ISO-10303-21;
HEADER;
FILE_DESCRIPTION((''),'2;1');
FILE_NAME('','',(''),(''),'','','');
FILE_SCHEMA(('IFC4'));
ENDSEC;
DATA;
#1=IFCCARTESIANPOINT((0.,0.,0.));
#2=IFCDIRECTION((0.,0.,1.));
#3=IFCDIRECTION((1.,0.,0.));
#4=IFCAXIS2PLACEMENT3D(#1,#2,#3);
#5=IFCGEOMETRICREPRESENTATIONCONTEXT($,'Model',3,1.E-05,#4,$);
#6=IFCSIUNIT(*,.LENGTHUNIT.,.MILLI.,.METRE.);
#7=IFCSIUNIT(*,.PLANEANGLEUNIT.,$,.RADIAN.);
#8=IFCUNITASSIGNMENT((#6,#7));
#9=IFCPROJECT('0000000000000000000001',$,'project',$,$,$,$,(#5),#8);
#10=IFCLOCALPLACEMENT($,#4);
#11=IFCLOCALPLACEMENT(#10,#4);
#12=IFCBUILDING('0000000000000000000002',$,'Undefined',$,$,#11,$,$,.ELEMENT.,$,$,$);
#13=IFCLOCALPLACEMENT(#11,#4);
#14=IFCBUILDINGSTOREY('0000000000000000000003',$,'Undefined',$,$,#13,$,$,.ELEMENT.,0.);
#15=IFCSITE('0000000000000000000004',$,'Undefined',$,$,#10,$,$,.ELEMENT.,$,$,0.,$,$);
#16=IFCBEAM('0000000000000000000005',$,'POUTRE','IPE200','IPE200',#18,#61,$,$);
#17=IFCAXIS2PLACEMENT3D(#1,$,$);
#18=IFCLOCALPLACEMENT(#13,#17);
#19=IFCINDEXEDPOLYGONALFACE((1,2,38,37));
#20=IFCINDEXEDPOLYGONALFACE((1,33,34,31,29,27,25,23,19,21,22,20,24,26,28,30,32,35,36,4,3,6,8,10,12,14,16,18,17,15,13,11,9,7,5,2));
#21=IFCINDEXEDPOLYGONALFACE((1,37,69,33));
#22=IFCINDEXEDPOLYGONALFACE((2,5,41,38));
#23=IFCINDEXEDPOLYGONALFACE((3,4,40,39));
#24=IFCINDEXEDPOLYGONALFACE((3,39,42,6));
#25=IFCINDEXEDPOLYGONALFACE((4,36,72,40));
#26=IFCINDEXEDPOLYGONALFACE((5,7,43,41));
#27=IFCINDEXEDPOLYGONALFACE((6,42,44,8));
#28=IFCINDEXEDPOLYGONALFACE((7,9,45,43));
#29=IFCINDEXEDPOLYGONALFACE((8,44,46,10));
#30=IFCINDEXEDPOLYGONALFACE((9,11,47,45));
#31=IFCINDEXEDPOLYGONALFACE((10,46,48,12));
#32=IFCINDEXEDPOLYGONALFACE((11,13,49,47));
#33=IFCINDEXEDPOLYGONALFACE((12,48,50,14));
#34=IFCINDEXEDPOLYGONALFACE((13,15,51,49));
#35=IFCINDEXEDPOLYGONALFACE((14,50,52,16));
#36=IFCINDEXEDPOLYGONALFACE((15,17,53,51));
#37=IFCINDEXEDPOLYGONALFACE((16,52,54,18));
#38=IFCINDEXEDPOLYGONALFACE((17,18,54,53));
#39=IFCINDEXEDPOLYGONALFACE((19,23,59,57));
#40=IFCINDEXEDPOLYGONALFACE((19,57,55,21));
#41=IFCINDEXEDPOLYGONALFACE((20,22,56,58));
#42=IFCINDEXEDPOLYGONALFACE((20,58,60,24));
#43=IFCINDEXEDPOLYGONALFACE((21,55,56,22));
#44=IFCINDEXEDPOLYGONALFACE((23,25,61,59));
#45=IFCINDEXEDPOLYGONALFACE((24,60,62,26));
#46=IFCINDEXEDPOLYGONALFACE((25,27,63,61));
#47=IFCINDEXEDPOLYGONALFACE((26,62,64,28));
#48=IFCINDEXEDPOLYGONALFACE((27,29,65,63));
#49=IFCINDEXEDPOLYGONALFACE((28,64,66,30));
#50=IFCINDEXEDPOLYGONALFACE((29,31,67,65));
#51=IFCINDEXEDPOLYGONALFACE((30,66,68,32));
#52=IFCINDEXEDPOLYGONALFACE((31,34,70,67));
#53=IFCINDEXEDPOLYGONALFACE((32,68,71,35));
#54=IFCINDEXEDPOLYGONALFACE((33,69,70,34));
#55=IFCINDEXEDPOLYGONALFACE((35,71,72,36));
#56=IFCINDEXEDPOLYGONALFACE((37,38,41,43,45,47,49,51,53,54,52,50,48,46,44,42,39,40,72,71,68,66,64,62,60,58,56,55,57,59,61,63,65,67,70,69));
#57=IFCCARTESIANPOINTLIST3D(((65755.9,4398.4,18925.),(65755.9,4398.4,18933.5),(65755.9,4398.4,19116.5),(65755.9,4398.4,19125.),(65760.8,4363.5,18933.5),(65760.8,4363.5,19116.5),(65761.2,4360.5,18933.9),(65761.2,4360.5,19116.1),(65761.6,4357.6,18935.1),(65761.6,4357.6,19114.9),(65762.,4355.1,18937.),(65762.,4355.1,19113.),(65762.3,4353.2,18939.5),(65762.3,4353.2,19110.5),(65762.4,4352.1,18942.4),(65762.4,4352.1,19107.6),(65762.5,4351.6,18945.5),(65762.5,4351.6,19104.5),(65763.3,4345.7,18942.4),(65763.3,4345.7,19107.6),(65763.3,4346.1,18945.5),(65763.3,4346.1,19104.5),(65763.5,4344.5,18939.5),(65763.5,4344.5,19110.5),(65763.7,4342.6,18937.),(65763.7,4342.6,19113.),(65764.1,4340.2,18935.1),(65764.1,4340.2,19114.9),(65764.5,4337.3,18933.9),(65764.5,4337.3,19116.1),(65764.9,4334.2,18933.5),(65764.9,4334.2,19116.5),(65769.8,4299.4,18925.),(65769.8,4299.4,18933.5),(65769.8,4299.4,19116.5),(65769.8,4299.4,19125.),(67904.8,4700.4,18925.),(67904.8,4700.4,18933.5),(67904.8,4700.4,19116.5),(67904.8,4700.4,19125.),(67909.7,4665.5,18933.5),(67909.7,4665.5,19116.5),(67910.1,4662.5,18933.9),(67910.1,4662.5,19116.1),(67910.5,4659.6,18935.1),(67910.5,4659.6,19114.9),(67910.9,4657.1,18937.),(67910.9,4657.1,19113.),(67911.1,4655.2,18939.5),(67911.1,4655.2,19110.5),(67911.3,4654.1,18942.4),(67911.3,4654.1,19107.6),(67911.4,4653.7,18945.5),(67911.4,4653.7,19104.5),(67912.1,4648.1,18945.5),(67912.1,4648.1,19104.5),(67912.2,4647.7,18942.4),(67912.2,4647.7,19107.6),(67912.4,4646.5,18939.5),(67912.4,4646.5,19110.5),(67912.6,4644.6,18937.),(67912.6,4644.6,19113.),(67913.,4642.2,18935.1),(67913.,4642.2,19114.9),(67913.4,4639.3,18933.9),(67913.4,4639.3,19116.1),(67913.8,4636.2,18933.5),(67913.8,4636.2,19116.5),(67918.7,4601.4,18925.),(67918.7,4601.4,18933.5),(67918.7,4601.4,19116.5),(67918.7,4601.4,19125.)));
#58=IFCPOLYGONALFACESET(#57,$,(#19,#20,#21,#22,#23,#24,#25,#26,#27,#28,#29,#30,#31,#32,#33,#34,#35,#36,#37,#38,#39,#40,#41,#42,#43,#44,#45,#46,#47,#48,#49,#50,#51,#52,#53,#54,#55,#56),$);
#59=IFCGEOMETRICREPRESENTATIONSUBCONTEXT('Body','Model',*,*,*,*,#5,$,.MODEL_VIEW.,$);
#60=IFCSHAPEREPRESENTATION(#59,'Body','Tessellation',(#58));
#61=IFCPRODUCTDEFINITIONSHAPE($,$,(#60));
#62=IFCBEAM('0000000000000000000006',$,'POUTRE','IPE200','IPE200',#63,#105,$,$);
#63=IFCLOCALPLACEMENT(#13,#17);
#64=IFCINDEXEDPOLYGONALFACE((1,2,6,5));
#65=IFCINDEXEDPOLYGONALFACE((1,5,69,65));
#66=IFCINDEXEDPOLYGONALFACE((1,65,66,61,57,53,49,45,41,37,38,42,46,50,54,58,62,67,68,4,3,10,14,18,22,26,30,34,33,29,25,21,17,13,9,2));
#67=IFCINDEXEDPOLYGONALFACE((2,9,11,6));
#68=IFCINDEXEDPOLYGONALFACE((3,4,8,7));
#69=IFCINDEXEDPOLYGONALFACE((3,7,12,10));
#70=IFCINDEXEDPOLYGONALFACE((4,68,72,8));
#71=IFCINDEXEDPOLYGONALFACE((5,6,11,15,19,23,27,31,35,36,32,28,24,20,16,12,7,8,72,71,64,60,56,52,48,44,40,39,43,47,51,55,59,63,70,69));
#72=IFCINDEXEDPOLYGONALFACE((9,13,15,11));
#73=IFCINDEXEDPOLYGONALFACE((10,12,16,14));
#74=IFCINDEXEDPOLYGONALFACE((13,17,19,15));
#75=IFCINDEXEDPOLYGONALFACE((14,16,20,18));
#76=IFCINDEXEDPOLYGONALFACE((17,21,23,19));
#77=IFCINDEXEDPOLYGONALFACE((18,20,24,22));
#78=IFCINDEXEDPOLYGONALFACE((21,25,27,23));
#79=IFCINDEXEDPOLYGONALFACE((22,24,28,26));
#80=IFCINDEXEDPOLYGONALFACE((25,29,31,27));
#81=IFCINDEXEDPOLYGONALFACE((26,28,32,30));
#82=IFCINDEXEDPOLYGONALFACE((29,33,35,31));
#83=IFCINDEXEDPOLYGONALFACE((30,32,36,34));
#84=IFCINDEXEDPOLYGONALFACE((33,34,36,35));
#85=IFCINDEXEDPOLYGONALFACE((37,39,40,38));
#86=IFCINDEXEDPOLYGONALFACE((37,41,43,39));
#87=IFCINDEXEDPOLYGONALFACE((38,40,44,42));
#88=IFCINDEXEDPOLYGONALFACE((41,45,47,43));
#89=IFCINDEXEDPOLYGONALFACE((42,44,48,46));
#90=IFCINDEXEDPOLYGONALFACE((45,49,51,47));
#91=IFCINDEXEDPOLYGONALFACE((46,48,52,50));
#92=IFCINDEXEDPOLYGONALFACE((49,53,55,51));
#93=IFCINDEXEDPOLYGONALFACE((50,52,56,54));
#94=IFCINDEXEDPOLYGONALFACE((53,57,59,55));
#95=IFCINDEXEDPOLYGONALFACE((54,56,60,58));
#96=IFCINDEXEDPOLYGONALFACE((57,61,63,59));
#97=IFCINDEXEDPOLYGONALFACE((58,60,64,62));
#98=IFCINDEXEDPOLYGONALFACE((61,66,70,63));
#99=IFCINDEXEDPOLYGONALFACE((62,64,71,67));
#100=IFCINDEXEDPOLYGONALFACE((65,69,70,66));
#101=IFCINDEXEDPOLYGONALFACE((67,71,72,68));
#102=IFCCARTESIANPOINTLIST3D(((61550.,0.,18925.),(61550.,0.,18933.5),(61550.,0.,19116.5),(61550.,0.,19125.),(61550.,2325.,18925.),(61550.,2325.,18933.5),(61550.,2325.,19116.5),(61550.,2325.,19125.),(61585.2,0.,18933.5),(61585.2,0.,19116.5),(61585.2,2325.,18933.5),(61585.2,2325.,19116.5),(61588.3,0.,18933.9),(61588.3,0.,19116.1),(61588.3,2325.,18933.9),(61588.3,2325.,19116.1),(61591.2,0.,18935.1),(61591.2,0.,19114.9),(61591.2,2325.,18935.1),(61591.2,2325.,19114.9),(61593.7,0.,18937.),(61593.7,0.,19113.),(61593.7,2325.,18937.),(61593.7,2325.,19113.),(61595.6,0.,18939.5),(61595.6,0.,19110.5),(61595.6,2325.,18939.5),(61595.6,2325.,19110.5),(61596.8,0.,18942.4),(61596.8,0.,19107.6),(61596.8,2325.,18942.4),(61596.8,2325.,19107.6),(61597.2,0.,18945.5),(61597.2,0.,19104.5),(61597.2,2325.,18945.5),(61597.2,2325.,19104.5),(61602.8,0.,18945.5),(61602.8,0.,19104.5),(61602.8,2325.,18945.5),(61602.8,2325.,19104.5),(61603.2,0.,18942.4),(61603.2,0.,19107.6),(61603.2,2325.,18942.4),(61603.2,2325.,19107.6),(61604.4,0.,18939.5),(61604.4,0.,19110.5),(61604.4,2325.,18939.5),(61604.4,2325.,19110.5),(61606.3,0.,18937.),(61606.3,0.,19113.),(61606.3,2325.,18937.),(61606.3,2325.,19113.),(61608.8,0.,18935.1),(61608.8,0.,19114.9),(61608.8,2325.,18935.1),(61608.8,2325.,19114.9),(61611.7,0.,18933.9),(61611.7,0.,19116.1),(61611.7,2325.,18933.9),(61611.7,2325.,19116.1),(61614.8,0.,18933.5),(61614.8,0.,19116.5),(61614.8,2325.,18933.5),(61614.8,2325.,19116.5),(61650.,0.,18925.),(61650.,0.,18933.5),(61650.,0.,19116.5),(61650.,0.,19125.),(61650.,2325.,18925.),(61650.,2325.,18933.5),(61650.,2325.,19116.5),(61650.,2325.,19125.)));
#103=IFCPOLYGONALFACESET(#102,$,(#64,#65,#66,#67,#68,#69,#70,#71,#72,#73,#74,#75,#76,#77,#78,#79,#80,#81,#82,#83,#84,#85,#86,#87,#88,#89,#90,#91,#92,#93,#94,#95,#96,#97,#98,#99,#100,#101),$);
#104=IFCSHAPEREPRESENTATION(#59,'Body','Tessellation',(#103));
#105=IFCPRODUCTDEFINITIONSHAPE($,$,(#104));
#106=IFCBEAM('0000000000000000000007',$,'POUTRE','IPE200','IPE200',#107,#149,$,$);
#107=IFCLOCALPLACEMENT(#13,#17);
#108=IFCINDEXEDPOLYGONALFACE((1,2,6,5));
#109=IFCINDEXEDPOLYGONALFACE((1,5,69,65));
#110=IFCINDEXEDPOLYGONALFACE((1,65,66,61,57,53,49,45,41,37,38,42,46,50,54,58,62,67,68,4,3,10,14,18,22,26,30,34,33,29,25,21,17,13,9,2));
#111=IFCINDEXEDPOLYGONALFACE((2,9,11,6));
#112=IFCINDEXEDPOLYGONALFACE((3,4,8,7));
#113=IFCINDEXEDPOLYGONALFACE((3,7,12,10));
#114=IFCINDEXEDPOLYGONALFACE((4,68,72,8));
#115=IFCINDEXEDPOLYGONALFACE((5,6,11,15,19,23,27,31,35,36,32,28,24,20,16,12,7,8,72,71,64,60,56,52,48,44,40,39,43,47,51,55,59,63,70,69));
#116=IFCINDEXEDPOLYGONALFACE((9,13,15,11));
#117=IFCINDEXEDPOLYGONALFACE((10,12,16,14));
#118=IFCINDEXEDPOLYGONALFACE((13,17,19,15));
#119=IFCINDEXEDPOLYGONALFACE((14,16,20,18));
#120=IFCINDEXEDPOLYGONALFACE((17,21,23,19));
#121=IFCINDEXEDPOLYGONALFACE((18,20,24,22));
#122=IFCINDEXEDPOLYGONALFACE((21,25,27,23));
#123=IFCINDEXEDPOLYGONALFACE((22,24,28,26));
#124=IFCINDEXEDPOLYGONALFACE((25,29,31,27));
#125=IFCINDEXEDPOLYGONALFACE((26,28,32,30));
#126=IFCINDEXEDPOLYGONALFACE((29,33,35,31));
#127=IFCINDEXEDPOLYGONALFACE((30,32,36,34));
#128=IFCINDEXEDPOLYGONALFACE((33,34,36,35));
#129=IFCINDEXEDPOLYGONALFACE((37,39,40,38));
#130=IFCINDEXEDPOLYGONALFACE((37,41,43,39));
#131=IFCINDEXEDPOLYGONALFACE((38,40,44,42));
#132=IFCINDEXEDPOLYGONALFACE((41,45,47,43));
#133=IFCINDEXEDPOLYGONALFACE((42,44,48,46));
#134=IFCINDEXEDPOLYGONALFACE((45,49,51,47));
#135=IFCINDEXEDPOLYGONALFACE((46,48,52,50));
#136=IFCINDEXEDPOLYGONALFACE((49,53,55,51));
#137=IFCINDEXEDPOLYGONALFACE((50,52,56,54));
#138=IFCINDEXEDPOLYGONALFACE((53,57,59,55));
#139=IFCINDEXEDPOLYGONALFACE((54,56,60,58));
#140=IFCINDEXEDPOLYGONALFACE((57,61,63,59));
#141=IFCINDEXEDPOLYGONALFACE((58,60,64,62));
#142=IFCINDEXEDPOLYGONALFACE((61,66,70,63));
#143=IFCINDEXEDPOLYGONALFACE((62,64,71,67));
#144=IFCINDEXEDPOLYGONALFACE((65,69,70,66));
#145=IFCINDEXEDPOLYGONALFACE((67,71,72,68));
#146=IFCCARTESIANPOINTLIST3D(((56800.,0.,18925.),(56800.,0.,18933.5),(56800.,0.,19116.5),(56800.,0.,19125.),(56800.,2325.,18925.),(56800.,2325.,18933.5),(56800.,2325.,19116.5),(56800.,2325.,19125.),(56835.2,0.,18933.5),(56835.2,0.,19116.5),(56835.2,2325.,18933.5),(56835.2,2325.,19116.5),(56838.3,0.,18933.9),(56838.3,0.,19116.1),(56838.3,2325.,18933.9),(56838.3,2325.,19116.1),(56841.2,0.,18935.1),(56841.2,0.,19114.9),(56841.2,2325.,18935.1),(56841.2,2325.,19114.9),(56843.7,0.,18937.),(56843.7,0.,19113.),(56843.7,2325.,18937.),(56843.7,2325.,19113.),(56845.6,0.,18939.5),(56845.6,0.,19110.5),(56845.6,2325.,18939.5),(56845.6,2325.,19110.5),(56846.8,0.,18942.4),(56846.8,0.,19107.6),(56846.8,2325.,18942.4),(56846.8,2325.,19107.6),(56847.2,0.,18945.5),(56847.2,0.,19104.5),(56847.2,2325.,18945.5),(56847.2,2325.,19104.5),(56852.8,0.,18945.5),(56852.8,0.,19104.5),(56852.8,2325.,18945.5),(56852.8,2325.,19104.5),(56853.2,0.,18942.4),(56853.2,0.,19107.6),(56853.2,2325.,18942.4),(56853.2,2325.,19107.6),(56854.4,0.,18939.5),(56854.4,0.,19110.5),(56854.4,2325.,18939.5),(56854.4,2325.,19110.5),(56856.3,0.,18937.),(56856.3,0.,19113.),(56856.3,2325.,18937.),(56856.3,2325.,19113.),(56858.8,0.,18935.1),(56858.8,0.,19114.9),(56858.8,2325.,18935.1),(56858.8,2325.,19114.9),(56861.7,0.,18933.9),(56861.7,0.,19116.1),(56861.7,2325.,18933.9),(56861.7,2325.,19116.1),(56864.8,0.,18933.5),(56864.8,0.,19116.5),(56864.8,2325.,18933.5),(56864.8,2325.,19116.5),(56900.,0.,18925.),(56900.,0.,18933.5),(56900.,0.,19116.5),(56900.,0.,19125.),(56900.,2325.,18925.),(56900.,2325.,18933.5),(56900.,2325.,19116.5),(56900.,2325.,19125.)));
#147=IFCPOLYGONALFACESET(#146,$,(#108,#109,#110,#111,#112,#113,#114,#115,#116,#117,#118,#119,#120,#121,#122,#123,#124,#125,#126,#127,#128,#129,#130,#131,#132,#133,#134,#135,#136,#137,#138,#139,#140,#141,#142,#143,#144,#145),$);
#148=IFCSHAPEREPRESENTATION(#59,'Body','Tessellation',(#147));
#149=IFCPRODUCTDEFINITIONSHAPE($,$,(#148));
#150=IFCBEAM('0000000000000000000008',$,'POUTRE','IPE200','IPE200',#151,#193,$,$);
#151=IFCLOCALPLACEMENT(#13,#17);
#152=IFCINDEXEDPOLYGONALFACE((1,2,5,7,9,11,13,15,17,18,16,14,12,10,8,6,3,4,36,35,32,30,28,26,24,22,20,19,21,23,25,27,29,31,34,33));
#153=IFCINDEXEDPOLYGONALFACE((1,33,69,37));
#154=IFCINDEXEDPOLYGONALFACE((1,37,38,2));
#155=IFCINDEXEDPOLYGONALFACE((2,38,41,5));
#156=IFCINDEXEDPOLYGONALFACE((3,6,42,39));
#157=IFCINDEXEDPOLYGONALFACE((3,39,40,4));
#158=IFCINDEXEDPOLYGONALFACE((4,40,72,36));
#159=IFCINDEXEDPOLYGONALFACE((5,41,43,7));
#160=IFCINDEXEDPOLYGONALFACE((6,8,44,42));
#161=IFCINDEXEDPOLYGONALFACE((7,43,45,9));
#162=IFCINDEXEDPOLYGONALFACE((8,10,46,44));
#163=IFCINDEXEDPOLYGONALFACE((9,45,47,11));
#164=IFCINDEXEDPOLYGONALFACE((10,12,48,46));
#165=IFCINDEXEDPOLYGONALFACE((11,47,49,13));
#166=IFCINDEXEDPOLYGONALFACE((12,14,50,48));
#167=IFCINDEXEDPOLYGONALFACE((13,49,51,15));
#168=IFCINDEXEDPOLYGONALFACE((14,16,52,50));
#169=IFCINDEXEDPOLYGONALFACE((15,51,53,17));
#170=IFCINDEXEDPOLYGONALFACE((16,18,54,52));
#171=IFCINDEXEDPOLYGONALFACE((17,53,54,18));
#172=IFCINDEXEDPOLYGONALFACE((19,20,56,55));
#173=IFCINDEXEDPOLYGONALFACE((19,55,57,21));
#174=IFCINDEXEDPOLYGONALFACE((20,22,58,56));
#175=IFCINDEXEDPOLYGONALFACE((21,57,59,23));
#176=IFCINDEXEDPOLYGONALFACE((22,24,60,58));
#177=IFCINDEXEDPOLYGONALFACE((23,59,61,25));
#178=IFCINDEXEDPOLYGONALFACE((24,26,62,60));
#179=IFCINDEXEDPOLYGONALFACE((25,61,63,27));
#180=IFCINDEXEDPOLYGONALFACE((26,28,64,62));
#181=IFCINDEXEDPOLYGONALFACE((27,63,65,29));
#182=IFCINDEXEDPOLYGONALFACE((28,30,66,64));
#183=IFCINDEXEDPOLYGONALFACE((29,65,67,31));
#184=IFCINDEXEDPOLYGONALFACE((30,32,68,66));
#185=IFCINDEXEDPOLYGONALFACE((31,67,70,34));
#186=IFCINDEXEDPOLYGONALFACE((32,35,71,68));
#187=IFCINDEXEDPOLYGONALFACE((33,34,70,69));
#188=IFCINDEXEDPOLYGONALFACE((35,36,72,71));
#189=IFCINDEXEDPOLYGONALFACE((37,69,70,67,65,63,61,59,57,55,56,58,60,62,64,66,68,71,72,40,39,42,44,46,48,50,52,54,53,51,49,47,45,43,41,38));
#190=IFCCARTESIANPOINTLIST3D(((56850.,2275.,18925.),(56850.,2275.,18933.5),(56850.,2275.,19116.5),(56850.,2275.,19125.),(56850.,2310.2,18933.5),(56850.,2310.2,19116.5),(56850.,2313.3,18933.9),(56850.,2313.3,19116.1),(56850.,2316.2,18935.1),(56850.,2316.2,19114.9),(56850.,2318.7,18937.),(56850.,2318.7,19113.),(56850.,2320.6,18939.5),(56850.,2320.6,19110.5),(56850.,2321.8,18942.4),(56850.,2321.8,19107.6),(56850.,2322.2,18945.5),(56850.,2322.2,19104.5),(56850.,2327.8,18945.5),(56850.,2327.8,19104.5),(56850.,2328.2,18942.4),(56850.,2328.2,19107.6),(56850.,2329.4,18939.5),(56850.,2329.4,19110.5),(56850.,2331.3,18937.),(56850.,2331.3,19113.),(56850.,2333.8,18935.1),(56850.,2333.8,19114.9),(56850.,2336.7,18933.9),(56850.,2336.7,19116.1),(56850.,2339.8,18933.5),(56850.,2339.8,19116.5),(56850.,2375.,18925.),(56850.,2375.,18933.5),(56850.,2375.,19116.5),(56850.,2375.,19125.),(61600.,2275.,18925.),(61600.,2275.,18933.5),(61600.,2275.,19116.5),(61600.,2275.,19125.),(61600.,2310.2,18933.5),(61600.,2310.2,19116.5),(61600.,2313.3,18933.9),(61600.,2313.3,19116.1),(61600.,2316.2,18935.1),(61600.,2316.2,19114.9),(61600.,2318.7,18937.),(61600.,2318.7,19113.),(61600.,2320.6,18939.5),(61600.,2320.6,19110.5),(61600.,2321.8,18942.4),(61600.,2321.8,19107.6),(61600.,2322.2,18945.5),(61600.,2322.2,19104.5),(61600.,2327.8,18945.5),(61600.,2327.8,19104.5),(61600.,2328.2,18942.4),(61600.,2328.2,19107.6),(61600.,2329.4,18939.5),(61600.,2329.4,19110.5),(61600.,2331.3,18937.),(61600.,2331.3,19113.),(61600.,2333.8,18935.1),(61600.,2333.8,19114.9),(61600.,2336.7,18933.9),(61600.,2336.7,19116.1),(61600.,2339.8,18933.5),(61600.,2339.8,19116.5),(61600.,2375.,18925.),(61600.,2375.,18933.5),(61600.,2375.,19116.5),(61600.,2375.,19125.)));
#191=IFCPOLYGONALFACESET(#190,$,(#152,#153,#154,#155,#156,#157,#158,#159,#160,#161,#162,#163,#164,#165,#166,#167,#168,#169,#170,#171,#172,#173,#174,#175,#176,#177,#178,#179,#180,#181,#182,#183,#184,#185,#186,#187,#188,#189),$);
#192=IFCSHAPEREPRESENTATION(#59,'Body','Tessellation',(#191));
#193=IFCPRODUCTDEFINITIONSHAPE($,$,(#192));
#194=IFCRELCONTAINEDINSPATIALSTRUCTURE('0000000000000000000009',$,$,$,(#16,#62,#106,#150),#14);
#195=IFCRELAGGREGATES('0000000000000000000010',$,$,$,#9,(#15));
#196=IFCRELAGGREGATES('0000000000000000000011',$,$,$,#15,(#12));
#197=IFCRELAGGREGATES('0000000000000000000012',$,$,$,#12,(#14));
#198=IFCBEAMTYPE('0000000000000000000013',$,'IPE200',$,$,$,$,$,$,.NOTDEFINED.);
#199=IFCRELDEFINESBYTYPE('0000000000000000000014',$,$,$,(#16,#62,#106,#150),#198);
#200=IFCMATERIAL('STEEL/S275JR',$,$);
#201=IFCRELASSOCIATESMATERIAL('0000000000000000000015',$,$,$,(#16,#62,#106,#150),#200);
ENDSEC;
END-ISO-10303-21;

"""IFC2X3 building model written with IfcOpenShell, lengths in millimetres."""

from ifc_helpers import new_model, si_unit, frame, origin_with_axes, origin_2d_with_axis, place, context, subcontext, project, spatial, i_section, extrude, material, type_object, element, save


model = new_model("IFC2X3")

# Units and contexts
model_context = context("Model", 3, precision=1e-05, world=origin_with_axes())
body_context = subcontext(model_context, "Body", "Model", "MODEL_VIEW")
ifc_project = project(units=[si_unit("LENGTHUNIT", "METRE", prefix="MILLI"), si_unit("PLANEANGLEUNIT", "RADIAN")], contexts=[model_context])

# Site, building, storey
site_placement = place(None, origin_with_axes())
site = spatial("IfcSite", under=ifc_project, at=site_placement, Name="Undefined", CompositionType="ELEMENT", RefElevation=0.0)
building_placement = place(site_placement, origin_with_axes())
building = spatial("IfcBuilding", under=site, at=building_placement, Name="Undefined", CompositionType="ELEMENT")
storey_placement = place(building_placement, origin_with_axes())
storey = spatial("IfcBuildingStorey", under=building, at=storey_placement, Name="Undefined", CompositionType="ELEMENT", Elevation=0.0)

# Shared definitions
ifc_material_1 = material(Name="STEEL/S275JR")

# Beams
beam_type_1 = type_object("IfcBeamType", Name="IPE200", PredefinedType="NOTDEFINED")
beam_1_placement = place(storey_placement, frame((67911.7, 4650.9, 19025.0), z_axis=(-0.000014, -0.000002, 1.0), x_axis=(-0.990268, -0.139173, -0.000014)))
element("IfcBeam", 1, at=beam_1_placement, inside=storey, type_object=beam_type_1, material=ifc_material_1, Name="POUTRE", Description="IPE200", ObjectType="IPE200", context=body_context, shape_type="SweptSolid", body=[
    extrude(i_section(OverallWidth=100.0, OverallDepth=200.0, WebThickness=5.6, FlangeThickness=8.5, FilletRadius=12.0, at=origin_2d_with_axis()), frame((2170.0, 0.0, 0.0), z_axis=(-1.0, 0.0, 0.0), x_axis=(0.0, -1.0, 0.0)), (0.0, 0.0, 1.0), 2170.0),
])
for number, where, z_axis, x_axis, name in (
    (2, (61600.0, 0.0, 19025.0), (0.0, 0.000013, 1.0), (0.0, 1.0, -0.000013), "POUTRE"),
    (3, (56850.0, 0.0, 19025.0), (0.0, 0.000013, 1.0), (0.0, 1.0, -0.000013), "POUTRE"),
):
    element("IfcBeam", number, at=place(storey_placement, frame(where, z_axis=z_axis, x_axis=x_axis)), inside=storey, type_object=beam_type_1, material=ifc_material_1, Name=name, Description="IPE200", ObjectType="IPE200", context=body_context, shape_type="SweptSolid", body=[
        extrude(i_section(OverallWidth=100.0, OverallDepth=200.0, WebThickness=5.6, FlangeThickness=8.5, FilletRadius=12.0, at=origin_2d_with_axis()), frame((2325.0, 0.0, 0.0), z_axis=(-1.0, 0.0, 0.0), x_axis=(0.0, -1.0, 0.0)), (0.0, 0.0, 1.0), 2325.0),
    ])
for number, where, z_axis, x_axis, name in (
    (4, (56850.0, 2325.0, 19025.0), (0.0, 0.0, 1.0), (1.0, 0.0, 0.0), "POUTRE"),
):
    element("IfcBeam", number, at=place(storey_placement, frame(where, z_axis=z_axis, x_axis=x_axis)), inside=storey, type_object=beam_type_1, material=ifc_material_1, Name=name, Description="IPE200", ObjectType="IPE200", context=body_context, shape_type="SweptSolid", body=[
        extrude(i_section(OverallWidth=100.0, OverallDepth=200.0, WebThickness=5.6, FlangeThickness=8.5, FilletRadius=12.0, at=origin_2d_with_axis()), frame((4750.0, 0.0, 0.0), z_axis=(-1.0, 0.0, 0.0), x_axis=(0.0, -1.0, 0.0)), (0.0, 0.0, 1.0), 4750.0),
    ])

save(model, "model.ifc")
